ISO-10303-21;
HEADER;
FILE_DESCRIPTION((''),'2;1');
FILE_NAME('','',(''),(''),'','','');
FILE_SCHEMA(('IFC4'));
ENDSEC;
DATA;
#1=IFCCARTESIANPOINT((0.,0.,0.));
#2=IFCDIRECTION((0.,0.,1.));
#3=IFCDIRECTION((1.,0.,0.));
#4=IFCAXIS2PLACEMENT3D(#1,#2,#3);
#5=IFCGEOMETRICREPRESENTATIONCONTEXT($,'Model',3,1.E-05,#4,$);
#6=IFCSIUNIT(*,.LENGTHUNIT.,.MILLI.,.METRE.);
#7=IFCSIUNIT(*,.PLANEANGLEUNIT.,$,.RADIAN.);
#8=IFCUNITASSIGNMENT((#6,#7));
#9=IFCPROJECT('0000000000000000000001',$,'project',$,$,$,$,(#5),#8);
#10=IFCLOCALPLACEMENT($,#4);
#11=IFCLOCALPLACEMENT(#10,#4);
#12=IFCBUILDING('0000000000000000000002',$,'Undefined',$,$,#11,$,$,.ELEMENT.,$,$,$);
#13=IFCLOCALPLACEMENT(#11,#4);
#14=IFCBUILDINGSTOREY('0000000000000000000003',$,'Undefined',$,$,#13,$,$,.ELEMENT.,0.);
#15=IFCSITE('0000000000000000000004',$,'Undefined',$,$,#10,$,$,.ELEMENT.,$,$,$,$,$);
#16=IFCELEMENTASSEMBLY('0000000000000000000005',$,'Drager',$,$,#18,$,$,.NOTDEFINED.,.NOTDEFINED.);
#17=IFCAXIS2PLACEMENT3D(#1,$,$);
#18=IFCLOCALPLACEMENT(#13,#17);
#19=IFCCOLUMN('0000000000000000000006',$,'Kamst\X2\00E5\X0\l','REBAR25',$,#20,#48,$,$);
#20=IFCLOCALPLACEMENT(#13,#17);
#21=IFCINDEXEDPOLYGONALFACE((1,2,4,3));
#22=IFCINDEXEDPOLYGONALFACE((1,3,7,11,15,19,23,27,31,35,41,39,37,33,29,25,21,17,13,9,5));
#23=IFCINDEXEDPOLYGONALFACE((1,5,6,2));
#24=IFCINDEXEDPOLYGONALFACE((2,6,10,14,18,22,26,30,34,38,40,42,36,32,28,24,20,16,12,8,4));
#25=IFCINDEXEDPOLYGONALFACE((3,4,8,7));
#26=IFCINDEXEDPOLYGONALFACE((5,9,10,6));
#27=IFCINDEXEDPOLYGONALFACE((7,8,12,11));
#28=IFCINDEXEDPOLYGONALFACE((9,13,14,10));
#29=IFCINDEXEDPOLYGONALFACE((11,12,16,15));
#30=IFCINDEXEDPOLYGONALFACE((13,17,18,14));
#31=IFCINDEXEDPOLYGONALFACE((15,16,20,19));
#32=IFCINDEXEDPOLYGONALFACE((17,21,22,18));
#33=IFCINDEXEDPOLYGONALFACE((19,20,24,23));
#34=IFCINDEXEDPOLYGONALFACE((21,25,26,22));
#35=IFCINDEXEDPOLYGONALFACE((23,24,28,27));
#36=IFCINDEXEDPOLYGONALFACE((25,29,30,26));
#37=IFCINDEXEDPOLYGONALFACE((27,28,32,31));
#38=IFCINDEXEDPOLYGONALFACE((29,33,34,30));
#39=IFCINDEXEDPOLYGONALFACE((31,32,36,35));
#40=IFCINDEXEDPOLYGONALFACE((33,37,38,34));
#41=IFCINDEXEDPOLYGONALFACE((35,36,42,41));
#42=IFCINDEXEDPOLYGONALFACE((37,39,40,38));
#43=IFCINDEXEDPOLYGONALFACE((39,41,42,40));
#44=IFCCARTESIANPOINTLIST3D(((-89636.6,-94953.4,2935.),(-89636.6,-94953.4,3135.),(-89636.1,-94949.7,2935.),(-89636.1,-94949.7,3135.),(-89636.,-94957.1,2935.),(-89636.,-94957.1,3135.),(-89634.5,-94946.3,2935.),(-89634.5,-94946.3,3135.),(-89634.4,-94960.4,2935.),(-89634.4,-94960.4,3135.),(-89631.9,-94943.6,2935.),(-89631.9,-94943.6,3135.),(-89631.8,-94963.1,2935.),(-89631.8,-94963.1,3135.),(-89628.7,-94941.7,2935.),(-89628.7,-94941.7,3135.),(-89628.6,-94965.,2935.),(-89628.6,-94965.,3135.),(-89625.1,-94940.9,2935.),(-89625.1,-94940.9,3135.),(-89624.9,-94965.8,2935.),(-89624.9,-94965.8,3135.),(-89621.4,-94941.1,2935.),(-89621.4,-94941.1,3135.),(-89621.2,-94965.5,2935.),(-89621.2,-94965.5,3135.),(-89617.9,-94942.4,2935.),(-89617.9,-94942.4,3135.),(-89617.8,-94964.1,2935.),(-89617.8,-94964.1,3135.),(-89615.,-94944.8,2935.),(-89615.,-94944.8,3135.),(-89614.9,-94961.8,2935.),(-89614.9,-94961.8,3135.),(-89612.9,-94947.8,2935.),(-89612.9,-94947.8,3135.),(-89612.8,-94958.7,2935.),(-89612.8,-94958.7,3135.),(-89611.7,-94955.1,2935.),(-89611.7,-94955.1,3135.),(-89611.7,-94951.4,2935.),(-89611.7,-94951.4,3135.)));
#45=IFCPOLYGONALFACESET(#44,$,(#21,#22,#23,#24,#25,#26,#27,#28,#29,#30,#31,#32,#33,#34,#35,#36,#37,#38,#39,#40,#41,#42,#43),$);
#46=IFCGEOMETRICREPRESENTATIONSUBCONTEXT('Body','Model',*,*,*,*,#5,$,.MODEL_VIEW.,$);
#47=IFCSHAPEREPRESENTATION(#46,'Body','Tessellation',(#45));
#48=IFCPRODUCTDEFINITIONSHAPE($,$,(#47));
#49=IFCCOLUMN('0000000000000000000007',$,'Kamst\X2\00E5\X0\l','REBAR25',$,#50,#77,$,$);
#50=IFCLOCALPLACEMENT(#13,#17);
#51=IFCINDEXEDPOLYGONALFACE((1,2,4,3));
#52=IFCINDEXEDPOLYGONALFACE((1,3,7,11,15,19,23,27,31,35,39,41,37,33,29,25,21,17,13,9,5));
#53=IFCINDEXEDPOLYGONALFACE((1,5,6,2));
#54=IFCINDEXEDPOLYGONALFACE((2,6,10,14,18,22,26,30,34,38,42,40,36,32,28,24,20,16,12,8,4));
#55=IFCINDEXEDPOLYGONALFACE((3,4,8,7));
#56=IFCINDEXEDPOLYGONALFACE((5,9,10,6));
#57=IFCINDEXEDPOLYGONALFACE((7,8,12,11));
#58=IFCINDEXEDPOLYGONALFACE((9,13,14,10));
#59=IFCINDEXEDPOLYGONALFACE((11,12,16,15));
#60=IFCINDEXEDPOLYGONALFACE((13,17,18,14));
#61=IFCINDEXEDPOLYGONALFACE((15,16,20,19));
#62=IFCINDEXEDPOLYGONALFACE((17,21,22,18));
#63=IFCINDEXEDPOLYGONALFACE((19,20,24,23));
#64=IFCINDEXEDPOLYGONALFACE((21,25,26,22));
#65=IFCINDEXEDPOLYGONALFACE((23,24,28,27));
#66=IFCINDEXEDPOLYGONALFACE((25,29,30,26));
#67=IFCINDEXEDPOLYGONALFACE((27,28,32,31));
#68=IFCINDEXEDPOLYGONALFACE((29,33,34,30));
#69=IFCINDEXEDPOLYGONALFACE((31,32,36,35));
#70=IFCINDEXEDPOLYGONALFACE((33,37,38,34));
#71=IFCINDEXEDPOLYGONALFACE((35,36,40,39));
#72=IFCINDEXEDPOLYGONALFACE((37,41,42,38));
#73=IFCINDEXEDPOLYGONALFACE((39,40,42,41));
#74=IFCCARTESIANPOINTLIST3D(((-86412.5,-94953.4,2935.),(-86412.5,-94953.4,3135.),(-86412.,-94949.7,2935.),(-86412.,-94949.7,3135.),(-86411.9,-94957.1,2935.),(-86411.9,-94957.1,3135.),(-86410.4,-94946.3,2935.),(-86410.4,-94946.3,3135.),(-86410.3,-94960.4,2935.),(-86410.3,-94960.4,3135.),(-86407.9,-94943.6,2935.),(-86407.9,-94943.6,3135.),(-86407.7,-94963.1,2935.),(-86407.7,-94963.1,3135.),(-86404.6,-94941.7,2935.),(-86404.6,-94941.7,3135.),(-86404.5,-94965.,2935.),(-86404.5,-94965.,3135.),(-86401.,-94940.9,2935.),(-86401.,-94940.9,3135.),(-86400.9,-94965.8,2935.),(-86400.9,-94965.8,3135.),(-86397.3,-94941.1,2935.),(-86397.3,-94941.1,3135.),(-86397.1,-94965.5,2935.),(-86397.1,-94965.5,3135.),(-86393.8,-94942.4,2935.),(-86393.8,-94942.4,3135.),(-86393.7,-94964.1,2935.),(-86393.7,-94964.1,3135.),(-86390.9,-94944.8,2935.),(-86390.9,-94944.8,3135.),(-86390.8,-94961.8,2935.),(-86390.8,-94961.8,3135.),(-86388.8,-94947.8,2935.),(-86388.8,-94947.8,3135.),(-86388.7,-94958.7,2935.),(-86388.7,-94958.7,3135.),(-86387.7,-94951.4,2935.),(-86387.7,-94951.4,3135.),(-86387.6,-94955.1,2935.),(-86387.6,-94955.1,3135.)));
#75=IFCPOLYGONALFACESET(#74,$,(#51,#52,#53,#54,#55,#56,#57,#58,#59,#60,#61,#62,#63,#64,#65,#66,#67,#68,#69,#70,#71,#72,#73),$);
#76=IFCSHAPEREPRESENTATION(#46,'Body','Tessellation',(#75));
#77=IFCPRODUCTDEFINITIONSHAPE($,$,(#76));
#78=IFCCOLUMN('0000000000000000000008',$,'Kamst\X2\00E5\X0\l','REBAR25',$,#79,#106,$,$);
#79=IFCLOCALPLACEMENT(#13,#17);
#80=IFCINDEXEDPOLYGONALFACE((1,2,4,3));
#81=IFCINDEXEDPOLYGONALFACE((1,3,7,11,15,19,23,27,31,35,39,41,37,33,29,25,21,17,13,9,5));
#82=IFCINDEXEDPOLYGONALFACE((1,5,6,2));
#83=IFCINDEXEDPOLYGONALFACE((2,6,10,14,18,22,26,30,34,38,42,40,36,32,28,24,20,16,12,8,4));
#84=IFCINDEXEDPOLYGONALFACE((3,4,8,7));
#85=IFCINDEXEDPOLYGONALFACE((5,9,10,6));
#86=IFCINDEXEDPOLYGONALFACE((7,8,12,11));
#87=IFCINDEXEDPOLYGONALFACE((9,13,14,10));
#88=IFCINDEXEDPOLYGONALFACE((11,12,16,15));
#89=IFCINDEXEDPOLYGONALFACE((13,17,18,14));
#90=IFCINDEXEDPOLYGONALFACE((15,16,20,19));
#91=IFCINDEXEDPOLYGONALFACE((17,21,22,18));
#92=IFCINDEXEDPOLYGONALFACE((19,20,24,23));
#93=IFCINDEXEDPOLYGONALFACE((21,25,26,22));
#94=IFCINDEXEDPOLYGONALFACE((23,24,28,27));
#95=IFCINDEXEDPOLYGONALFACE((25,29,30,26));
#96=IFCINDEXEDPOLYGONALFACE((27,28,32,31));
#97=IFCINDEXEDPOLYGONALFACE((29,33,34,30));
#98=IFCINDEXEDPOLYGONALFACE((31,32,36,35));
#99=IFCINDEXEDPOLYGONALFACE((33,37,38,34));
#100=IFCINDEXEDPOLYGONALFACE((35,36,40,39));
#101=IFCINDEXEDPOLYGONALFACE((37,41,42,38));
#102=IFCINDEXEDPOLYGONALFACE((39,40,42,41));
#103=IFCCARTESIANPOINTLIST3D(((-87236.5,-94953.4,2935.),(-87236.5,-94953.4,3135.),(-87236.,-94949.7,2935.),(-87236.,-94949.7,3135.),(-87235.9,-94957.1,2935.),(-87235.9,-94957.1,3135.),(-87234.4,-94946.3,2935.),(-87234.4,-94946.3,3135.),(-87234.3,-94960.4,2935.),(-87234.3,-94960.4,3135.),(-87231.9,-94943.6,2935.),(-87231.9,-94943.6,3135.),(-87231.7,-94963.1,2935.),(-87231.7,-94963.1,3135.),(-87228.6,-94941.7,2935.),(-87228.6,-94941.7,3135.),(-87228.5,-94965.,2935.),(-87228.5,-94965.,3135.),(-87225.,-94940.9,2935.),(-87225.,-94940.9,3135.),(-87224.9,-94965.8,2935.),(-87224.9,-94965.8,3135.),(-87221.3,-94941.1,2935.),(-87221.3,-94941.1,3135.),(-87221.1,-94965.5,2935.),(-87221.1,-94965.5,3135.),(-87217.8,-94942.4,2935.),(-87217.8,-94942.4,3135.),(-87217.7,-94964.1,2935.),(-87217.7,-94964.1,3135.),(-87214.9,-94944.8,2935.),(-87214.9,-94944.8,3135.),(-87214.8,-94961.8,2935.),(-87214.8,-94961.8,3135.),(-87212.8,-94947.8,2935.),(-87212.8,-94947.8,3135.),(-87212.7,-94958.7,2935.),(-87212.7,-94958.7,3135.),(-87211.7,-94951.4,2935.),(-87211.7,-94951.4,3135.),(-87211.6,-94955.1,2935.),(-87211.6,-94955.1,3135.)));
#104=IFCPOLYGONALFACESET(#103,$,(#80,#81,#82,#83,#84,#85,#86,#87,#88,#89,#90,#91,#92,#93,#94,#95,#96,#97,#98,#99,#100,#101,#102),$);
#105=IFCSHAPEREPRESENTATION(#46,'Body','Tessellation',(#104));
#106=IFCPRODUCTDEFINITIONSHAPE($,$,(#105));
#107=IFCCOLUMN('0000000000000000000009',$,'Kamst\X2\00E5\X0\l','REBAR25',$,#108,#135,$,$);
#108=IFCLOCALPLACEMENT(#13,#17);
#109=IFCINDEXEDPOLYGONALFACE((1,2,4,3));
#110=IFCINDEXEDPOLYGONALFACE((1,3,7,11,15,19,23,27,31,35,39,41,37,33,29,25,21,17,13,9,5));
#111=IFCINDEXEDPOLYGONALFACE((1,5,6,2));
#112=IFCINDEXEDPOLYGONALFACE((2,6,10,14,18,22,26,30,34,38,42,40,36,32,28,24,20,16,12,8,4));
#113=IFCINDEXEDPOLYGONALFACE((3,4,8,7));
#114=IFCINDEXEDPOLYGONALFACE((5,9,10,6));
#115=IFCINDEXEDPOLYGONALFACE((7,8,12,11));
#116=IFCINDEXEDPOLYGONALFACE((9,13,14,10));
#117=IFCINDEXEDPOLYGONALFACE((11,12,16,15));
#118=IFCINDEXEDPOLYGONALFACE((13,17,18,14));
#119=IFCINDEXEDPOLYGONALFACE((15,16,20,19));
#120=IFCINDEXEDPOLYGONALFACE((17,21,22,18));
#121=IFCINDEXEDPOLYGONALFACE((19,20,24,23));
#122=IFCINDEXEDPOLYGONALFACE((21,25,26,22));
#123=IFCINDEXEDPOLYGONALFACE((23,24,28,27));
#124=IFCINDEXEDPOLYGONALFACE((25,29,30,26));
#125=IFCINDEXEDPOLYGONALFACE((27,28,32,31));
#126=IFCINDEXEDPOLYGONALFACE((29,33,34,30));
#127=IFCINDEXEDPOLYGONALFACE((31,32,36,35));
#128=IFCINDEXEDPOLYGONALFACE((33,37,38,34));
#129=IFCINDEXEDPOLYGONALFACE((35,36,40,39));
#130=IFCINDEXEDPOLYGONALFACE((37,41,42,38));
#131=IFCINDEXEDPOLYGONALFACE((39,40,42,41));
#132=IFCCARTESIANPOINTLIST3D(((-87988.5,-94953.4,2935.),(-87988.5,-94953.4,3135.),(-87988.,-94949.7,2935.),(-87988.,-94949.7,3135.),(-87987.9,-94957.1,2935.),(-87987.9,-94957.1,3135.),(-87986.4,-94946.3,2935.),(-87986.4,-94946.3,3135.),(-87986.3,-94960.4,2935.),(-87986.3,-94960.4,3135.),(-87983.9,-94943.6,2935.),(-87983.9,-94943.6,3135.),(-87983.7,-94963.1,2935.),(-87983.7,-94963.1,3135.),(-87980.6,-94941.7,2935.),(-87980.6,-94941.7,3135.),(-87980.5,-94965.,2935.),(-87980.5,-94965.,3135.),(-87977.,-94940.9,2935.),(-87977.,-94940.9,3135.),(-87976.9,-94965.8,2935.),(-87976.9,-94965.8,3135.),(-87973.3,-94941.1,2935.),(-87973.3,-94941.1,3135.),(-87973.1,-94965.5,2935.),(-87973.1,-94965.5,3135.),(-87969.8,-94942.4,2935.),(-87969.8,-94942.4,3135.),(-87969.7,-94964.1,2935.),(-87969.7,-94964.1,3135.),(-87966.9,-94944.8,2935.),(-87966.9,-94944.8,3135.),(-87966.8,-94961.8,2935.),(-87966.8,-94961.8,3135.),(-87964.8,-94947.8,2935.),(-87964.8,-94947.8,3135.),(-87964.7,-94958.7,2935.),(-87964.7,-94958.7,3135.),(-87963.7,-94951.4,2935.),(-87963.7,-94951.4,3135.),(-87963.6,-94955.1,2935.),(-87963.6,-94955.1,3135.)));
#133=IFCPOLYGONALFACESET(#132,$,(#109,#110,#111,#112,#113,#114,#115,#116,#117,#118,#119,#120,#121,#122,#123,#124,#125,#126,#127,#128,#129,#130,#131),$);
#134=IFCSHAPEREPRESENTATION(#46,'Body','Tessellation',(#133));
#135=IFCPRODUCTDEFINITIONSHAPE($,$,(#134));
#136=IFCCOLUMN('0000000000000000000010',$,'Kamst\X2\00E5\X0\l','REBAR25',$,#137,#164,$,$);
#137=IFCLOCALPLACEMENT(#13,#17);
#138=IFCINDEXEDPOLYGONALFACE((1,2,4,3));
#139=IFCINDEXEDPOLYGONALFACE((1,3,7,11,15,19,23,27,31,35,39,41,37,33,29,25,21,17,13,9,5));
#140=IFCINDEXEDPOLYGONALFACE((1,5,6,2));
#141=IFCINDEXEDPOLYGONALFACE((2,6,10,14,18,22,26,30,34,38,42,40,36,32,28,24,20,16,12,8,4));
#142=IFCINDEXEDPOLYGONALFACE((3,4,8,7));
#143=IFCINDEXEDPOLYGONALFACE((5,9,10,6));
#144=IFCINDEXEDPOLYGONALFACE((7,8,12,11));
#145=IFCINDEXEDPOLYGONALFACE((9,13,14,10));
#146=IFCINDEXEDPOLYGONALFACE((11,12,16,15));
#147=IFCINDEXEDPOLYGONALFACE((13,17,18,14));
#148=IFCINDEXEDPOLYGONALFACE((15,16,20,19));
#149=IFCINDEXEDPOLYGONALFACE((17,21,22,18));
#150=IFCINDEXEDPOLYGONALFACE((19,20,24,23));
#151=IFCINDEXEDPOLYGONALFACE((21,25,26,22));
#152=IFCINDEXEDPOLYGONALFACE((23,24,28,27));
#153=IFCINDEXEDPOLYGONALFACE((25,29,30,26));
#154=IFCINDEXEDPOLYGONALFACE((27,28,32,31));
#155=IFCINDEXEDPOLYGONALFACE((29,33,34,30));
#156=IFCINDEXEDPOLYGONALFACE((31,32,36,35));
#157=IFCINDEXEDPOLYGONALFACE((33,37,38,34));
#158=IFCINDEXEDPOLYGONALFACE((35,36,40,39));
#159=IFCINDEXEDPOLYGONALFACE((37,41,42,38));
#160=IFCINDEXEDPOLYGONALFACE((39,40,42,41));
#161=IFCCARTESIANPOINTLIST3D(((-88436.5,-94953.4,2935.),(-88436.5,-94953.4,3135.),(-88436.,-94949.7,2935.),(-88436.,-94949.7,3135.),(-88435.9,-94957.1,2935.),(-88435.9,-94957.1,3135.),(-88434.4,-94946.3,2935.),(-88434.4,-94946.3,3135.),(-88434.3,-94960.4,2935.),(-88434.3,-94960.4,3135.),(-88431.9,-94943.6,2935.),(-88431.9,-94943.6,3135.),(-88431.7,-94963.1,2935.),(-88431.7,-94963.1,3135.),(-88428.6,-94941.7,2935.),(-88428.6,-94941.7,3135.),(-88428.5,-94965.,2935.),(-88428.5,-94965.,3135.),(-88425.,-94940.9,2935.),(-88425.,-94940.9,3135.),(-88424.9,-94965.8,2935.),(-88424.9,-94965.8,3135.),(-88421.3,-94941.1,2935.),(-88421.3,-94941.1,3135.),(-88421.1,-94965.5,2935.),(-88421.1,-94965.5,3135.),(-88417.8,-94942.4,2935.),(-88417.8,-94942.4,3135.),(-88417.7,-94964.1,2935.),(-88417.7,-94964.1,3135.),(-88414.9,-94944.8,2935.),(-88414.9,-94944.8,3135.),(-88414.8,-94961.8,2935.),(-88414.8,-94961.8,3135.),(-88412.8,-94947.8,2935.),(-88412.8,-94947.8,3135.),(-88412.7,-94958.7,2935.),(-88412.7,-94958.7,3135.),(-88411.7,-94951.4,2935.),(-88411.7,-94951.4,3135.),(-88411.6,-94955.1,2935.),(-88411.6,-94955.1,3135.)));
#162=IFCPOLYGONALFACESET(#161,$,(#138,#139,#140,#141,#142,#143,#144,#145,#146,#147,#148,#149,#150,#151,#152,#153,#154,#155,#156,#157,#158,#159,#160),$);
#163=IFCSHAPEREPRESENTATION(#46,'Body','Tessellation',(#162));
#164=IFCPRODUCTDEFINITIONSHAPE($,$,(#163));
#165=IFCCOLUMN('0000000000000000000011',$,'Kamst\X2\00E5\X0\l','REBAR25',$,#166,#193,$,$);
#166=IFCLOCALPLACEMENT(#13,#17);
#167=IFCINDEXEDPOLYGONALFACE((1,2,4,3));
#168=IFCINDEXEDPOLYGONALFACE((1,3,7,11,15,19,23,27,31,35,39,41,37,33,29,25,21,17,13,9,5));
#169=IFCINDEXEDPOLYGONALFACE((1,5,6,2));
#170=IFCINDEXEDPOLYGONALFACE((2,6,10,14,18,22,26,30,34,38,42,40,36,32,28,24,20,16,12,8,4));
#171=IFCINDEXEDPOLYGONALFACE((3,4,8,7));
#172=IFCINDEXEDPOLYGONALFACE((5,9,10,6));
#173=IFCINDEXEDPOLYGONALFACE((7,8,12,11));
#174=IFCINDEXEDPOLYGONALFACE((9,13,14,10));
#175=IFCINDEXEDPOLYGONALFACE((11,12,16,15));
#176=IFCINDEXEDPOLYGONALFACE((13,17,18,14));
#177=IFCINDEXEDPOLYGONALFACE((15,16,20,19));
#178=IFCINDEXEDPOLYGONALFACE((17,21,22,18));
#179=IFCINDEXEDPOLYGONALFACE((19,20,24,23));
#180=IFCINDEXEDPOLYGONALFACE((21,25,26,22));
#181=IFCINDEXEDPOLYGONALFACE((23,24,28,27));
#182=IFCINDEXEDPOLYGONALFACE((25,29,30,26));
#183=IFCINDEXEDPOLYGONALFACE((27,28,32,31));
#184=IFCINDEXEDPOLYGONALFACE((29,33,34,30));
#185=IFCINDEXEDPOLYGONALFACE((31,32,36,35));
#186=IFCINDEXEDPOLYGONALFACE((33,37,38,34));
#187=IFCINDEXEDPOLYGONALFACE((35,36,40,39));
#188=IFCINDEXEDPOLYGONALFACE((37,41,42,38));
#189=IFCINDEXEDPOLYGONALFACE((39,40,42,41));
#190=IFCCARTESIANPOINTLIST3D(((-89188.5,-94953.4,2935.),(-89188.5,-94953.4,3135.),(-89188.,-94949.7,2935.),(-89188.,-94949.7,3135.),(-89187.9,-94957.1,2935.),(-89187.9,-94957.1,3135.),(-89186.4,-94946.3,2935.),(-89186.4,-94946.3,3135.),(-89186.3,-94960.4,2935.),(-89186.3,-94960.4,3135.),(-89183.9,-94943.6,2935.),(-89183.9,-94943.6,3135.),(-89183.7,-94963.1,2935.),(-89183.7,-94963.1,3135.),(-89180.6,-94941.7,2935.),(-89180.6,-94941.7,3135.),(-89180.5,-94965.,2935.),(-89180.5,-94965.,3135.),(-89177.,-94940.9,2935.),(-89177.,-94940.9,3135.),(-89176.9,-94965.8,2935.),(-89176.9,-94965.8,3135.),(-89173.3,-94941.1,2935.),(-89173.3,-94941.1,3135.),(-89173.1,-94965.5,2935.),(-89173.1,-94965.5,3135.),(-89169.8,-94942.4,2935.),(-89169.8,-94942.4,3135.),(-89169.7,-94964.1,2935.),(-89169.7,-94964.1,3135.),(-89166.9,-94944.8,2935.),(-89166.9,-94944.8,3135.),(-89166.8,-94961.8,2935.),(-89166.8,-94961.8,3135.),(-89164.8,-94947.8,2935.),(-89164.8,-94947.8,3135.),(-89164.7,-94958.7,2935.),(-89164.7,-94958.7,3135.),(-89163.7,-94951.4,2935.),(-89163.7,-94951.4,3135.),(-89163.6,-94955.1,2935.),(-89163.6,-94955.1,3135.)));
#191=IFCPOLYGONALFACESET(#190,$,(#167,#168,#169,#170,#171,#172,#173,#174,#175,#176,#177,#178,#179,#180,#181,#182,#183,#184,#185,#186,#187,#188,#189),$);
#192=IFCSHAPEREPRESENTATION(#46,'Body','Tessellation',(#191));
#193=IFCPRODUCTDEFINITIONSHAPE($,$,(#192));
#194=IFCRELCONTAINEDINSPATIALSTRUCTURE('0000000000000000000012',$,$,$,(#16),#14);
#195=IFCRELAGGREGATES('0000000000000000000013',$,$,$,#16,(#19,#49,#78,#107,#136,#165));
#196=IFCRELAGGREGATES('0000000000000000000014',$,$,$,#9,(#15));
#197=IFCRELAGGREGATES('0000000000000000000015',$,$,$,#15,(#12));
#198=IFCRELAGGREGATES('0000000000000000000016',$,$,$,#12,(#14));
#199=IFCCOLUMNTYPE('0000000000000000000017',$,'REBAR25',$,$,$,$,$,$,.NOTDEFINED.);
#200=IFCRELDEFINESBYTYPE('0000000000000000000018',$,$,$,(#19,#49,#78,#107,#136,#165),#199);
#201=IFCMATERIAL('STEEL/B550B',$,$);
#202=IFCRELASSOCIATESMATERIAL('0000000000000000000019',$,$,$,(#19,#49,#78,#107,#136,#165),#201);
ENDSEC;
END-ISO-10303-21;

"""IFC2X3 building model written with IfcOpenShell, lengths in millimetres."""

from ifc_helpers import new_model, si_unit, frame, origin_with_axes, origin_2d_with_axis, place, context, subcontext, project, spatial, circle, extrude, material, type_object, element, aggregate, save


model = new_model("IFC2X3")

# Units and contexts
model_context = context("Model", 3, precision=1e-05, world=origin_with_axes())
body_context = subcontext(model_context, "Body", "Model", "MODEL_VIEW")
ifc_project = project(units=[si_unit("LENGTHUNIT", "METRE", prefix="MILLI"), si_unit("PLANEANGLEUNIT", "RADIAN")], contexts=[model_context])

# Site, building, storey
site_placement = place(None, origin_with_axes())
site = spatial("IfcSite", under=ifc_project, at=site_placement, Name="Undefined", CompositionType="ELEMENT")
building_placement = place(site_placement, origin_with_axes())
building = spatial("IfcBuilding", under=site, at=building_placement, Name="Undefined", CompositionType="ELEMENT")
storey_placement = place(building_placement, origin_with_axes())
storey = spatial("IfcBuildingStorey", under=building, at=storey_placement, Name="Undefined", CompositionType="ELEMENT", Elevation=0.0)

# Element assembly, columns
assembly_1_placement = place(storey_placement, origin_with_axes())
assembly_1 = element("IfcElementAssembly", 1, at=assembly_1_placement, inside=storey, Name="Drager", AssemblyPlace="NOTDEFINED", PredefinedType="NOTDEFINED")
ifc_material_1 = material(Name="STEEL/B550B")
column_type_1 = type_object("IfcColumnType", Name="REBAR25", PredefinedType="NOTDEFINED")
column_1_placement = place(assembly_1_placement, frame((-89624.1, -94953.3, 2935.0), z_axis=(0.0, 0.0, 1.0), x_axis=(-0.862746, -0.505638, 0.0)))
column_1 = element("IfcColumn", 2, at=column_1_placement, type_object=column_type_1, material=ifc_material_1, Name="Kamstål", Description="REBAR25", context=body_context, shape_type="SweptSolid", body=[
    extrude(circle(Radius=12.5, at=origin_2d_with_axis()), frame((0.0, 0.0, 200.0), z_axis=(0.0, 0.0, -1.0), x_axis=(0.0, 1.0, 0.0)), (0.0, 0.0, 1.0), 200.0),
])
column_2_placement = place(assembly_1_placement, frame((-86400.0, -94953.3, 2935.0), z_axis=(0.0, 0.0, 1.0), x_axis=(-0.862746, -0.505638, 0.0)))
column_2 = element("IfcColumn", 3, at=column_2_placement, type_object=column_type_1, material=ifc_material_1, Name="Kamstål", Description="REBAR25", context=body_context, shape_type="SweptSolid", body=[
    extrude(circle(Radius=12.5, at=origin_2d_with_axis()), frame((0.0, 0.0, 200.0), z_axis=(0.0, 0.0, -1.0), x_axis=(0.0, 1.0, 0.0)), (0.0, 0.0, 1.0), 200.0),
])
column_3_placement = place(assembly_1_placement, frame((-87224.0, -94953.3, 2935.0), z_axis=(0.0, 0.0, 1.0), x_axis=(-0.862746, -0.505638, 0.0)))
column_3 = element("IfcColumn", 4, at=column_3_placement, type_object=column_type_1, material=ifc_material_1, Name="Kamstål", Description="REBAR25", context=body_context, shape_type="SweptSolid", body=[
    extrude(circle(Radius=12.5, at=origin_2d_with_axis()), frame((0.0, 0.0, 200.0), z_axis=(0.0, 0.0, -1.0), x_axis=(0.0, 1.0, 0.0)), (0.0, 0.0, 1.0), 200.0),
])
column_4_placement = place(assembly_1_placement, frame((-87976.0, -94953.3, 2935.0), z_axis=(0.0, 0.0, 1.0), x_axis=(-0.862746, -0.505638, 0.0)))
column_4 = element("IfcColumn", 5, at=column_4_placement, type_object=column_type_1, material=ifc_material_1, Name="Kamstål", Description="REBAR25", context=body_context, shape_type="SweptSolid", body=[
    extrude(circle(Radius=12.5, at=origin_2d_with_axis()), frame((0.0, 0.0, 200.0), z_axis=(0.0, 0.0, -1.0), x_axis=(0.0, 1.0, 0.0)), (0.0, 0.0, 1.0), 200.0),
])
column_5_placement = place(assembly_1_placement, frame((-88424.0, -94953.3, 2935.0), z_axis=(0.0, 0.0, 1.0), x_axis=(-0.862746, -0.505638, 0.0)))
column_5 = element("IfcColumn", 6, at=column_5_placement, type_object=column_type_1, material=ifc_material_1, Name="Kamstål", Description="REBAR25", context=body_context, shape_type="SweptSolid", body=[
    extrude(circle(Radius=12.5, at=origin_2d_with_axis()), frame((0.0, 0.0, 200.0), z_axis=(0.0, 0.0, -1.0), x_axis=(0.0, 1.0, 0.0)), (0.0, 0.0, 1.0), 200.0),
])
column_6_placement = place(assembly_1_placement, frame((-89176.0, -94953.3, 2935.0), z_axis=(0.0, 0.0, 1.0), x_axis=(-0.862746, -0.505638, 0.0)))
column_6 = element("IfcColumn", 7, at=column_6_placement, type_object=column_type_1, material=ifc_material_1, Name="Kamstål", Description="REBAR25", context=body_context, shape_type="SweptSolid", body=[
    extrude(circle(Radius=12.5, at=origin_2d_with_axis()), frame((0.0, 0.0, 200.0), z_axis=(0.0, 0.0, -1.0), x_axis=(0.0, 1.0, 0.0)), (0.0, 0.0, 1.0), 200.0),
])
aggregate(assembly_1, [column_1, column_2, column_3, column_4, column_5, column_6])

save(model, "model.ifc")
